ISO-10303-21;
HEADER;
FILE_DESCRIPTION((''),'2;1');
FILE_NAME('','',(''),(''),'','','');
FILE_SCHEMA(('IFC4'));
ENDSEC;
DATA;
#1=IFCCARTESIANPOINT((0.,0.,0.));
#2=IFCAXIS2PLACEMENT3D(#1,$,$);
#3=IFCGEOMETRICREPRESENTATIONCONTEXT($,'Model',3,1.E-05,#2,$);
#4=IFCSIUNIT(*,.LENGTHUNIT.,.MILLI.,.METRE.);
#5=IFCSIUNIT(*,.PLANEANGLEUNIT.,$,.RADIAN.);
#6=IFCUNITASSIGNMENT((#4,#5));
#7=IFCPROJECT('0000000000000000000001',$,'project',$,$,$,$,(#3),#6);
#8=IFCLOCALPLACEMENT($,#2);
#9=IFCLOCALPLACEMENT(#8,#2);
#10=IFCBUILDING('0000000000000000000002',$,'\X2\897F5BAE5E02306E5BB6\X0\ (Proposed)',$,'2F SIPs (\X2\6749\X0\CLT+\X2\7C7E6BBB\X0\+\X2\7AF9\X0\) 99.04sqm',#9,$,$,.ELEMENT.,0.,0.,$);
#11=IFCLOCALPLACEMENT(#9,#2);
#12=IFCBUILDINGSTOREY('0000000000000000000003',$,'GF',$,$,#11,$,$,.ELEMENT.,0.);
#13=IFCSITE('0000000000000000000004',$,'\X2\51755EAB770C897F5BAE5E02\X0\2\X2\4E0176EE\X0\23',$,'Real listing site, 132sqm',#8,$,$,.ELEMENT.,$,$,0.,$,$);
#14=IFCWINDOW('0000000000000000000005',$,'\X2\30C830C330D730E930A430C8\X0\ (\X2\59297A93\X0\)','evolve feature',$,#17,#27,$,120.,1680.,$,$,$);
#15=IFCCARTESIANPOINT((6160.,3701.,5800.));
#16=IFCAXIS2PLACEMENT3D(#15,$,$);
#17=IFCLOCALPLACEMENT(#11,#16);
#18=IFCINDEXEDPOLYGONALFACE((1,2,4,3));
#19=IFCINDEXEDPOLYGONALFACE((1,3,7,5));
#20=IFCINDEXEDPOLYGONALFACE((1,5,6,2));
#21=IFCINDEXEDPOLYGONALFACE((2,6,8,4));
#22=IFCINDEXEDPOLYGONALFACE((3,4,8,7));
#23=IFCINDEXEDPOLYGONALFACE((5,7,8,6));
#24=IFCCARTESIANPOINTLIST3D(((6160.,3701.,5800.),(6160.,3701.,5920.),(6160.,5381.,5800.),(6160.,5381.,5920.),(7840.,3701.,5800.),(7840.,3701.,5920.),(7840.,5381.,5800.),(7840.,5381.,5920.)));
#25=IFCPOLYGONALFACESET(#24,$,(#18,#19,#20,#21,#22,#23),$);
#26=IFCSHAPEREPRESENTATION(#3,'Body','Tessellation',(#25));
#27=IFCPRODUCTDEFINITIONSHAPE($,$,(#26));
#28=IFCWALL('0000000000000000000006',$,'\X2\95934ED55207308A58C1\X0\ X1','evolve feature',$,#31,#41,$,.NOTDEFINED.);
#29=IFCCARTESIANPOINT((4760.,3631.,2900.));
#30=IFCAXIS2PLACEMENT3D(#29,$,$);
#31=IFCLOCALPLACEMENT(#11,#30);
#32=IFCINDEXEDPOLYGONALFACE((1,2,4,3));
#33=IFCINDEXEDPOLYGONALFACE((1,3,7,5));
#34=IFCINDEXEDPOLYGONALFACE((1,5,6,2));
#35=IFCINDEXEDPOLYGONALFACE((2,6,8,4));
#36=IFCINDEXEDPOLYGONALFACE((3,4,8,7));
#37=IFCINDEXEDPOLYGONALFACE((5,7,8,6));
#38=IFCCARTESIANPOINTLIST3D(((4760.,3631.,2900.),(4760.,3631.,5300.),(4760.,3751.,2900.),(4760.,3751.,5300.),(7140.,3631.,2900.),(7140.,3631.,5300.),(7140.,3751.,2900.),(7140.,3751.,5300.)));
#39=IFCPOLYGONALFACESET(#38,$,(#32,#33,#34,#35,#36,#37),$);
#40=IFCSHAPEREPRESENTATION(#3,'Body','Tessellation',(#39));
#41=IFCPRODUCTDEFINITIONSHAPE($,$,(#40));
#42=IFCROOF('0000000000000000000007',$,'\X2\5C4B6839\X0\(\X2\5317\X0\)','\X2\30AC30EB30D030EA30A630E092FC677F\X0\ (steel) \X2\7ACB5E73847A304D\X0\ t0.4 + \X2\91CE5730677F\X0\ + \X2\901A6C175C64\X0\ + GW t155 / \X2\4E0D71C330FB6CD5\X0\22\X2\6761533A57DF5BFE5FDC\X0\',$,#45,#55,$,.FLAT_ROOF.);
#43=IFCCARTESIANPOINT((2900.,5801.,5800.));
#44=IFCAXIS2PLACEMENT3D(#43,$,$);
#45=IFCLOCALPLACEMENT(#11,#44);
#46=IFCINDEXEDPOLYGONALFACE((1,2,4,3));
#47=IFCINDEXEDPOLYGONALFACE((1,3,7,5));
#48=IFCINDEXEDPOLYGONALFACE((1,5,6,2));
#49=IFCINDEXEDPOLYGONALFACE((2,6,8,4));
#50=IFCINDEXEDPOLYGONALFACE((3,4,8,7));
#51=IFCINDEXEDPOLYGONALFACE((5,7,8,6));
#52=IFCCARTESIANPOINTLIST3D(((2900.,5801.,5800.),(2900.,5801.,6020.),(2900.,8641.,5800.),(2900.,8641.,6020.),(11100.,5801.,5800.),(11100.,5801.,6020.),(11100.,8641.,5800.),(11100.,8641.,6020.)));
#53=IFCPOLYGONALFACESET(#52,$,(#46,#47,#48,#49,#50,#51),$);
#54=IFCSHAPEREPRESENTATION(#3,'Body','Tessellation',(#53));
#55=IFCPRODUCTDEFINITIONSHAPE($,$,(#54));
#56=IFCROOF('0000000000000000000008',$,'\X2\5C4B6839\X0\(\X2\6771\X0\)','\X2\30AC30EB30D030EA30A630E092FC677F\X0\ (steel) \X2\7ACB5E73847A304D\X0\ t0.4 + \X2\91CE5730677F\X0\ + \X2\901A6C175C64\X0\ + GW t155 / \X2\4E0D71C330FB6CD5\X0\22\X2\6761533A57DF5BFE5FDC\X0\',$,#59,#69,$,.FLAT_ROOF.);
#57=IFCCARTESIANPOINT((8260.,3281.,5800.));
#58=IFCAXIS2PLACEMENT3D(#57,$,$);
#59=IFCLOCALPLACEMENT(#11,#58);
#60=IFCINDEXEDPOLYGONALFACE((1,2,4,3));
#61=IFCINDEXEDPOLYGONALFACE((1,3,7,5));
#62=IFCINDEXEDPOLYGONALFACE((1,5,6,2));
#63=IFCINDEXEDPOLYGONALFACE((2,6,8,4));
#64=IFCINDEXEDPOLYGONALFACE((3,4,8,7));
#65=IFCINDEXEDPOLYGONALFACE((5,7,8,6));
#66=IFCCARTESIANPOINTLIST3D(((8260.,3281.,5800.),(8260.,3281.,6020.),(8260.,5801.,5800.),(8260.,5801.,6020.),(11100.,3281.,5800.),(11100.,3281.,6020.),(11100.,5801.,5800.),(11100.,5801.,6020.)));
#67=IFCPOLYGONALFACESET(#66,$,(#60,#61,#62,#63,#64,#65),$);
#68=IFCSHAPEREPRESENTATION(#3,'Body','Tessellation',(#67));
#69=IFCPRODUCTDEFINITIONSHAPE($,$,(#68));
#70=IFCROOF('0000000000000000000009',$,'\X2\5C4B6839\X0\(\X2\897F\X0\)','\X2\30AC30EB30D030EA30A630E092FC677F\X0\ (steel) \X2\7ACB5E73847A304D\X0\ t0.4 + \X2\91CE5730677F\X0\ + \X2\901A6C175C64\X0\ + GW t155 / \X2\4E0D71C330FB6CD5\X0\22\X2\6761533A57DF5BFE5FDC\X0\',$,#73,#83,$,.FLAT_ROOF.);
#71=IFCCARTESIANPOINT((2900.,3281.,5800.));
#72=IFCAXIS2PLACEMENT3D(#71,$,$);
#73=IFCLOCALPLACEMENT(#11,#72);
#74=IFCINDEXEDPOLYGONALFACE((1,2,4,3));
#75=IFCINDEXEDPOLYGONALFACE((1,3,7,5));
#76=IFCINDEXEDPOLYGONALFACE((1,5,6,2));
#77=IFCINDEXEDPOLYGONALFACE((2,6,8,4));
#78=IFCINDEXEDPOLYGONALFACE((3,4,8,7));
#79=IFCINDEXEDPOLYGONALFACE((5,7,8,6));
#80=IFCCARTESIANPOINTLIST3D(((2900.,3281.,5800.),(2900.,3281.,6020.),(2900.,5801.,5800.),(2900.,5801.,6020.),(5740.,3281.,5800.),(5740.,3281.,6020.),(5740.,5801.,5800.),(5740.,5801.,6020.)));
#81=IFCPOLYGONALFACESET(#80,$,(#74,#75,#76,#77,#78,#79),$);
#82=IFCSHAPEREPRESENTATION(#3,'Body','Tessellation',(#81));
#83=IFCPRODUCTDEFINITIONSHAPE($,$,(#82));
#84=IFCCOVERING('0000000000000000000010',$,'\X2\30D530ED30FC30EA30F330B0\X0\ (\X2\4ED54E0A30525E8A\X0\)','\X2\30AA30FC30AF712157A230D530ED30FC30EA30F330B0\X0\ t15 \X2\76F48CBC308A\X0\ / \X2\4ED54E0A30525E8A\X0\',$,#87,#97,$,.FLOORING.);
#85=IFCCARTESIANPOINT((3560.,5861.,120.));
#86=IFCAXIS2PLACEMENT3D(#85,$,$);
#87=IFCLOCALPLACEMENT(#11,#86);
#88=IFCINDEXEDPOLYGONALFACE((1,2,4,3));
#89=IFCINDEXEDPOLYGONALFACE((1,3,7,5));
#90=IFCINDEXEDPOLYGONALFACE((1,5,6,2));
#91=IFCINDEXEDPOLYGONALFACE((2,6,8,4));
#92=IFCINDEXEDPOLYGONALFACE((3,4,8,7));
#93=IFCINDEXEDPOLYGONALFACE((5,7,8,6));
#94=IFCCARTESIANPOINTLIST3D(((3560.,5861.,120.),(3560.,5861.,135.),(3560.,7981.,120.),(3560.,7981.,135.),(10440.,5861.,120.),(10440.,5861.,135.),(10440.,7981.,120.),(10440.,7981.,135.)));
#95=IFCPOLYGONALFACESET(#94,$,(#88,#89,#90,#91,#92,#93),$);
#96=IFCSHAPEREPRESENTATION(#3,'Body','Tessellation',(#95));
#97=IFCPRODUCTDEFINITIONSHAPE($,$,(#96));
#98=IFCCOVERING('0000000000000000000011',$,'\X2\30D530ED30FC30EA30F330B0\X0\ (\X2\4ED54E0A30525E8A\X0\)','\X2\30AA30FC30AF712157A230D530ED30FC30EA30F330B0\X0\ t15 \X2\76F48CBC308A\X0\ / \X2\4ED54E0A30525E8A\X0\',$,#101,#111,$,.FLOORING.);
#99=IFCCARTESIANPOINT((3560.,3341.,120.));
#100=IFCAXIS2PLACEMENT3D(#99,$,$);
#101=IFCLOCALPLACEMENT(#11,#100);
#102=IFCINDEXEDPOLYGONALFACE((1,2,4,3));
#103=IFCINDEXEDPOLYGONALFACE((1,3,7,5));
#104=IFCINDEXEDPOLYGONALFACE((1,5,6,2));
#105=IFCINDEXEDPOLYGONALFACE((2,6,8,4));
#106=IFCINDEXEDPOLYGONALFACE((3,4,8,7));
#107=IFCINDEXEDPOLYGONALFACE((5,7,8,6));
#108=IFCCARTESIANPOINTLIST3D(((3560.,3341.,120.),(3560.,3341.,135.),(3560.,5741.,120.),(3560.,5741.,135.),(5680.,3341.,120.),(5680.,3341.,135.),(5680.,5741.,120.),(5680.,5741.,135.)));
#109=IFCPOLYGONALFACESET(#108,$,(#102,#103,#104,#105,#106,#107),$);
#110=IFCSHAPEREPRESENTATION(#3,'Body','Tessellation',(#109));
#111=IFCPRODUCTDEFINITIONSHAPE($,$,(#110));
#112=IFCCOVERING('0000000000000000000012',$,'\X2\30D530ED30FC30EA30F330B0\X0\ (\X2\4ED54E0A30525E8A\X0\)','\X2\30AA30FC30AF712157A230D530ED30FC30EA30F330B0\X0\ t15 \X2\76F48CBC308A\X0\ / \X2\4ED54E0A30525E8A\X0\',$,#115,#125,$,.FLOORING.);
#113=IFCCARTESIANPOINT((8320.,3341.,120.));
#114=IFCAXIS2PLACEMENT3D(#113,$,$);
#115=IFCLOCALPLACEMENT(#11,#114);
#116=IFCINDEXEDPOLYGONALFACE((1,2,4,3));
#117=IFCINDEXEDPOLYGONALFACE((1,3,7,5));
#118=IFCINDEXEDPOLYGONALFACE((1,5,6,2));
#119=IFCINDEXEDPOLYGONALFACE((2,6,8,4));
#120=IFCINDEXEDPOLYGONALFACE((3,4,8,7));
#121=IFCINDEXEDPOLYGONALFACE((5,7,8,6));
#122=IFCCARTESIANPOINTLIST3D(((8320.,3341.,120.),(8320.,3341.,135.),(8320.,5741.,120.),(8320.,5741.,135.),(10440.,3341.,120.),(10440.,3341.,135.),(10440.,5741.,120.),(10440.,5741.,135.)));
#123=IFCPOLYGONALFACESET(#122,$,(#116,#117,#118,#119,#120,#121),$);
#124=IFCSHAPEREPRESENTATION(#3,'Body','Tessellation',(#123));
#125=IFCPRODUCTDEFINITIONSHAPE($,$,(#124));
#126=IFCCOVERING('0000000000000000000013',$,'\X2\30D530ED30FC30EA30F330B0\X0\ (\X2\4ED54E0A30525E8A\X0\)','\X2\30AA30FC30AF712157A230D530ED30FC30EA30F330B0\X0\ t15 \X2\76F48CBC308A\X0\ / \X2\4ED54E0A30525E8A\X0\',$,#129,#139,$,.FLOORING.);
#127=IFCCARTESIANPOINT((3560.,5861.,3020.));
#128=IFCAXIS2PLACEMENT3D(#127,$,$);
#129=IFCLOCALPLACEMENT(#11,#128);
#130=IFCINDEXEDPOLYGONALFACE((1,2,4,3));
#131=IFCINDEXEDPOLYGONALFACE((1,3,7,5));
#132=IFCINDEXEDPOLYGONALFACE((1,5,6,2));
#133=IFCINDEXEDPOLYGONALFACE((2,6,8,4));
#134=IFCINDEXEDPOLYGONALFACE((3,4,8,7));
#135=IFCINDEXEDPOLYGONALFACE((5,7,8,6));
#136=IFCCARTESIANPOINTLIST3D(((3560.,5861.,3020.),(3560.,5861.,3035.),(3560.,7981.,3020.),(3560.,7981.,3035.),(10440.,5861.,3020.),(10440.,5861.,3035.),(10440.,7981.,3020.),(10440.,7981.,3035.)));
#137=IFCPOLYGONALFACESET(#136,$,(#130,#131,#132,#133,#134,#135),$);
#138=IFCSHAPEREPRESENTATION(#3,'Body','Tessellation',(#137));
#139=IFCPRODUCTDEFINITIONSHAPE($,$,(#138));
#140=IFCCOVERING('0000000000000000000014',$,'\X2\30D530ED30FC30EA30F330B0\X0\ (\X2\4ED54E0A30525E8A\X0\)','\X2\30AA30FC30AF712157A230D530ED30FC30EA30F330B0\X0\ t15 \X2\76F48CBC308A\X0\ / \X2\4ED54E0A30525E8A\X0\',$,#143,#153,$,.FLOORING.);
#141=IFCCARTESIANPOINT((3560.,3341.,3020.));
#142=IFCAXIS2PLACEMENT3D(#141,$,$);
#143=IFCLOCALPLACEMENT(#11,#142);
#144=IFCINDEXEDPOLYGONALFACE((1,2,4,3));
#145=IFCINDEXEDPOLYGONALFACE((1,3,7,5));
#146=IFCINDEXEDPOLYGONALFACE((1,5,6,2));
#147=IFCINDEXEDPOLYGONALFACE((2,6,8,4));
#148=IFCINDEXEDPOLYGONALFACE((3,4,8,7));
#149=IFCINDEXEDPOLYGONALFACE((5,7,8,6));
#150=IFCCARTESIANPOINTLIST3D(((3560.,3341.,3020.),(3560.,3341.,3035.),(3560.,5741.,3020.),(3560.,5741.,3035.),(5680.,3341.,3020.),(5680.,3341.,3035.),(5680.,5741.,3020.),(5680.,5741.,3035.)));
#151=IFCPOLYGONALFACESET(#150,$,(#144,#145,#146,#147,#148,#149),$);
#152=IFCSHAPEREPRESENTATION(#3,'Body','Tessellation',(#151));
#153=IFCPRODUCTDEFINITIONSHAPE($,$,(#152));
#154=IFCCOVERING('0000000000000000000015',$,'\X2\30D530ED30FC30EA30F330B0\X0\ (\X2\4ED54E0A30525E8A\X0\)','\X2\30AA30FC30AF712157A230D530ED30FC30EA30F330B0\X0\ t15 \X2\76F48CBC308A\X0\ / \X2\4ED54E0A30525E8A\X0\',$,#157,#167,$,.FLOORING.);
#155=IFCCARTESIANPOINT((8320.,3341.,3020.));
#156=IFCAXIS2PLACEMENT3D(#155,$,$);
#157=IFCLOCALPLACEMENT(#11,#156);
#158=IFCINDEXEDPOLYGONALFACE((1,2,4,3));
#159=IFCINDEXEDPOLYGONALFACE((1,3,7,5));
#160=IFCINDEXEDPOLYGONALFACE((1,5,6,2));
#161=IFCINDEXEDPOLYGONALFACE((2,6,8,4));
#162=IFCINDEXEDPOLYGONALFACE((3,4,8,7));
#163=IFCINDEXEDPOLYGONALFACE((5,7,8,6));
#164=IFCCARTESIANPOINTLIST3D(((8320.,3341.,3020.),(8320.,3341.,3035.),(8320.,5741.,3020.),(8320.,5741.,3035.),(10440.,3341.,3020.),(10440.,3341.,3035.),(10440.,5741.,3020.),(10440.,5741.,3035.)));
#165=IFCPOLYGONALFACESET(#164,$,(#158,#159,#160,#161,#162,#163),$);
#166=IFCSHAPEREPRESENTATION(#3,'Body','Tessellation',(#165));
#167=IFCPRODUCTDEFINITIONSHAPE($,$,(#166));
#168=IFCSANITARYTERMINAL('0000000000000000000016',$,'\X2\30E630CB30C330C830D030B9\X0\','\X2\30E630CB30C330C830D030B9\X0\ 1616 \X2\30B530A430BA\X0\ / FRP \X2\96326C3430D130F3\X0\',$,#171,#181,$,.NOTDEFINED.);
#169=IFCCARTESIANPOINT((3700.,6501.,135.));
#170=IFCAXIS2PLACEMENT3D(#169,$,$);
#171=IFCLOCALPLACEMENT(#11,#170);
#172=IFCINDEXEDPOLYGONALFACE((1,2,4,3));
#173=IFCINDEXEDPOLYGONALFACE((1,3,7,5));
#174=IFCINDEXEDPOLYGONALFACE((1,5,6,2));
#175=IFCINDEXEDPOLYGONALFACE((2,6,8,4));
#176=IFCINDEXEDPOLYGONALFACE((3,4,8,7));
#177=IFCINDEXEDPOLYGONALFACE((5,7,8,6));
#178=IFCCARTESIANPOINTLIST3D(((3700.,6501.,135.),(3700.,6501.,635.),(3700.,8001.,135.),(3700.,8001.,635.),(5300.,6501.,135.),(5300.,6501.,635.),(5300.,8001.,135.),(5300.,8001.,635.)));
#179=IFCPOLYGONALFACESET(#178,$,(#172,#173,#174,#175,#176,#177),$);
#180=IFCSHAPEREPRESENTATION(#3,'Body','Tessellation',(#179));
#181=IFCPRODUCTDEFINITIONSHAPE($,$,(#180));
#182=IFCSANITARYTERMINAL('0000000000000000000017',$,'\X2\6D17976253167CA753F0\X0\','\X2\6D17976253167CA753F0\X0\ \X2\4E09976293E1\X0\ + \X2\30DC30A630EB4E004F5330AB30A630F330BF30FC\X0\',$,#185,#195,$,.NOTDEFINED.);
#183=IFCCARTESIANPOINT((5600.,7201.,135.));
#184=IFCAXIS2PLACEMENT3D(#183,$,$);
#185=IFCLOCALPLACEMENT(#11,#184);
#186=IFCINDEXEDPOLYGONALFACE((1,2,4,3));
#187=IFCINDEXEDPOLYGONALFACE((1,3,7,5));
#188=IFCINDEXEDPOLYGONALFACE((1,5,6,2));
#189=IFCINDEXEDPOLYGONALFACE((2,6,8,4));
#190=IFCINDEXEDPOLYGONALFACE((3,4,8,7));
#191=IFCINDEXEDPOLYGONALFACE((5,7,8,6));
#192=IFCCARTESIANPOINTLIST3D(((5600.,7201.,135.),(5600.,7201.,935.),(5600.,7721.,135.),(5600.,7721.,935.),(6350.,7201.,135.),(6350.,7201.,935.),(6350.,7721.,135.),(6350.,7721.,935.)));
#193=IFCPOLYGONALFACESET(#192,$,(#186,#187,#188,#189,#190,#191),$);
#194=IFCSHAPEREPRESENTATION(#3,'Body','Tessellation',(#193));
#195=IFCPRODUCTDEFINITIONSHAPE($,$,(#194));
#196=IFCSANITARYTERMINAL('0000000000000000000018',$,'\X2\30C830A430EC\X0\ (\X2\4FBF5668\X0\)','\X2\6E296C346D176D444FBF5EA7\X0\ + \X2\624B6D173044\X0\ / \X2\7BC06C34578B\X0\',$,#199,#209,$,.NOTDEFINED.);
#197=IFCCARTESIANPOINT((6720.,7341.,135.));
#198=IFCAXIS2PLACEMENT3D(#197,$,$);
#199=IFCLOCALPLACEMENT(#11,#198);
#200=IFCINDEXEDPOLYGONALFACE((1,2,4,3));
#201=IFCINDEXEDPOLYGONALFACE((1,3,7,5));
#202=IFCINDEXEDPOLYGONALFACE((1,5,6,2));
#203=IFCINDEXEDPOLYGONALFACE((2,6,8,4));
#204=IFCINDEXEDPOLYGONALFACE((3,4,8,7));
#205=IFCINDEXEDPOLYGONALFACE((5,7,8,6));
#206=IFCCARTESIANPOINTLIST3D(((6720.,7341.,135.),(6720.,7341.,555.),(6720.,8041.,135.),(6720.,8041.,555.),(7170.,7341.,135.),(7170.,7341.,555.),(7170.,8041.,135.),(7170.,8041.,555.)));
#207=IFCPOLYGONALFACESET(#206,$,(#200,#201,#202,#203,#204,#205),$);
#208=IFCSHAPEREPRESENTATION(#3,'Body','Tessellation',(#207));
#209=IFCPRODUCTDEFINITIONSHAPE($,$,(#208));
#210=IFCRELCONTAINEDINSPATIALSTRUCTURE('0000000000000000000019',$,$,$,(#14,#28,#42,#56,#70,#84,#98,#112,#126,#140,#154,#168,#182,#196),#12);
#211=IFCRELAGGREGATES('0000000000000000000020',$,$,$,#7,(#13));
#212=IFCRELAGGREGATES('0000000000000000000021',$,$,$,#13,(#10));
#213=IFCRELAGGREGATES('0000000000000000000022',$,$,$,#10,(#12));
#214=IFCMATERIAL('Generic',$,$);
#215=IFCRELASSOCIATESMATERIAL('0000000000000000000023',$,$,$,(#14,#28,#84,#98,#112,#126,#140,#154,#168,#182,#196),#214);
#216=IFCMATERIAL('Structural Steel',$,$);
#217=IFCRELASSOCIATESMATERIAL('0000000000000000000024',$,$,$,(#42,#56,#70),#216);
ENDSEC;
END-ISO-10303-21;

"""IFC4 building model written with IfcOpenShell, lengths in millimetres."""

from ifc_helpers import new_model, si_unit, frame, frame_2d, origin, place, context, project, spatial, rectangle, extrude, material, element, save


model = new_model("IFC4")

# Units and contexts
model_context = context("Model", 3, precision=1e-05, world=origin())
ifc_project = project(units=[si_unit("LENGTHUNIT", "METRE", prefix="MILLI"), si_unit("PLANEANGLEUNIT", "RADIAN")], contexts=[model_context])

# Site, building, storey
site_placement = place(None, origin())
site = spatial("IfcSite", under=ifc_project, at=site_placement, Name="兵庫県西宮市2丁目23", ObjectType="Real listing site, 132sqm", CompositionType="ELEMENT", RefElevation=0.0)
building_placement = place(site_placement, origin())
building = spatial("IfcBuilding", under=site, at=building_placement, Name="西宮市の家 (Proposed)", ObjectType="2F SIPs (杉CLT+籾殻+竹) 99.04sqm", CompositionType="ELEMENT", ElevationOfRefHeight=0.0, ElevationOfTerrain=0.0)
storey_placement = place(building_placement, origin())
storey = spatial("IfcBuildingStorey", under=building, at=storey_placement, Name="GF", CompositionType="ELEMENT", Elevation=0.0)

# Window
ifc_material_1 = material(Name="Generic")
window_1_placement = place(storey_placement, frame((6160.0, 3701.0, 5800.0)))
element("IfcWindow", 1, at=window_1_placement, inside=storey, material=ifc_material_1, Name="トップライト (天窓)", Description="evolve feature", OverallHeight=120.0, OverallWidth=1680.0, context=model_context, shape_type="SweptSolid", body=[
    extrude(rectangle(XDim=1680.0, YDim=1680.0, at=frame_2d((840.0, 840.0))), frame((6160.0, 3701.0, 5800.0)), (0.0, 0.0, 1.0), 120.0),
])

# Wall
wall_1_placement = place(storey_placement, frame((4760.0, 3631.0, 2900.0)))
element("IfcWall", 2, at=wall_1_placement, inside=storey, material=ifc_material_1, Name="間仕切り壁 X1", Description="evolve feature", PredefinedType="NOTDEFINED", context=model_context, shape_type="SweptSolid", body=[
    extrude(rectangle(XDim=2380.0, YDim=120.0, at=frame_2d((1190.0, 60.0))), frame((4760.0, 3631.0, 2900.0)), (0.0, 0.0, 1.0), 2400.0),
])

# Roofs
ifc_material_2 = material(Name="Structural Steel")
roof_1_placement = place(storey_placement, frame((2900.0, 5801.0, 5800.0)))
element("IfcRoof", 3, at=roof_1_placement, inside=storey, material=ifc_material_2, Name="屋根(北)", Description="ガルバリウム鋼板 (steel) 立平葺き t0.4 + 野地板 + 通気層 + GW t155 / 不燃・法22条区域対応", PredefinedType="FLAT_ROOF", context=model_context, shape_type="SweptSolid", body=[
    extrude(rectangle(XDim=8200.0, YDim=2840.0, at=frame_2d((4100.0, 1420.0))), frame((2900.0, 5801.0, 5800.0)), (0.0, 0.0, 1.0), 220.0),
])
roof_2_placement = place(storey_placement, frame((8260.0, 3281.0, 5800.0)))
element("IfcRoof", 4, at=roof_2_placement, inside=storey, material=ifc_material_2, Name="屋根(東)", Description="ガルバリウム鋼板 (steel) 立平葺き t0.4 + 野地板 + 通気層 + GW t155 / 不燃・法22条区域対応", PredefinedType="FLAT_ROOF", context=model_context, shape_type="SweptSolid", body=[
    extrude(rectangle(XDim=2840.0, YDim=2520.0, at=frame_2d((1420.0, 1260.0))), frame((8260.0, 3281.0, 5800.0)), (0.0, 0.0, 1.0), 220.0),
])
roof_3_placement = place(storey_placement, frame((2900.0, 3281.0, 5800.0)))
element("IfcRoof", 5, at=roof_3_placement, inside=storey, material=ifc_material_2, Name="屋根(西)", Description="ガルバリウム鋼板 (steel) 立平葺き t0.4 + 野地板 + 通気層 + GW t155 / 不燃・法22条区域対応", PredefinedType="FLAT_ROOF", context=model_context, shape_type="SweptSolid", body=[
    extrude(rectangle(XDim=2840.0, YDim=2520.0, at=frame_2d((1420.0, 1260.0))), frame((2900.0, 3281.0, 5800.0)), (0.0, 0.0, 1.0), 220.0),
])

# Coverings
covering_1_placement = place(storey_placement, frame((3560.0, 5861.0, 120.0)))
element("IfcCovering", 6, at=covering_1_placement, inside=storey, material=ifc_material_1, Name="フローリング (仕上げ床)", Description="オーク無垢フローリング t15 直貼り / 仕上げ床", PredefinedType="FLOORING", context=model_context, shape_type="SweptSolid", body=[
    extrude(rectangle(XDim=6880.0, YDim=2120.0, at=frame_2d((3440.0, 1060.0))), frame((3560.0, 5861.0, 120.0)), (0.0, 0.0, 1.0), 15.0),
])
covering_2_placement = place(storey_placement, frame((3560.0, 3341.0, 120.0)))
element("IfcCovering", 7, at=covering_2_placement, inside=storey, material=ifc_material_1, Name="フローリング (仕上げ床)", Description="オーク無垢フローリング t15 直貼り / 仕上げ床", PredefinedType="FLOORING", context=model_context, shape_type="SweptSolid", body=[
    extrude(rectangle(XDim=2120.0, YDim=2400.0, at=frame_2d((1060.0, 1200.0))), frame((3560.0, 3341.0, 120.0)), (0.0, 0.0, 1.0), 15.0),
])
covering_3_placement = place(storey_placement, frame((8320.0, 3341.0, 120.0)))
element("IfcCovering", 8, at=covering_3_placement, inside=storey, material=ifc_material_1, Name="フローリング (仕上げ床)", Description="オーク無垢フローリング t15 直貼り / 仕上げ床", PredefinedType="FLOORING", context=model_context, shape_type="SweptSolid", body=[
    extrude(rectangle(XDim=2120.0, YDim=2400.0, at=frame_2d((1060.0, 1200.0))), frame((8320.0, 3341.0, 120.0)), (0.0, 0.0, 1.0), 15.0),
])
covering_4_placement = place(storey_placement, frame((3560.0, 5861.0, 3020.0)))
element("IfcCovering", 9, at=covering_4_placement, inside=storey, material=ifc_material_1, Name="フローリング (仕上げ床)", Description="オーク無垢フローリング t15 直貼り / 仕上げ床", PredefinedType="FLOORING", context=model_context, shape_type="SweptSolid", body=[
    extrude(rectangle(XDim=6880.0, YDim=2120.0, at=frame_2d((3440.0, 1060.0))), frame((3560.0, 5861.0, 3020.0)), (0.0, 0.0, 1.0), 15.0),
])
covering_5_placement = place(storey_placement, frame((3560.0, 3341.0, 3020.0)))
element("IfcCovering", 10, at=covering_5_placement, inside=storey, material=ifc_material_1, Name="フローリング (仕上げ床)", Description="オーク無垢フローリング t15 直貼り / 仕上げ床", PredefinedType="FLOORING", context=model_context, shape_type="SweptSolid", body=[
    extrude(rectangle(XDim=2120.0, YDim=2400.0, at=frame_2d((1060.0, 1200.0))), frame((3560.0, 3341.0, 3020.0)), (0.0, 0.0, 1.0), 15.0),
])
covering_6_placement = place(storey_placement, frame((8320.0, 3341.0, 3020.0)))
element("IfcCovering", 11, at=covering_6_placement, inside=storey, material=ifc_material_1, Name="フローリング (仕上げ床)", Description="オーク無垢フローリング t15 直貼り / 仕上げ床", PredefinedType="FLOORING", context=model_context, shape_type="SweptSolid", body=[
    extrude(rectangle(XDim=2120.0, YDim=2400.0, at=frame_2d((1060.0, 1200.0))), frame((8320.0, 3341.0, 3020.0)), (0.0, 0.0, 1.0), 15.0),
])

# Sanitary terminals
sanitary_terminal_1_placement = place(storey_placement, frame((3700.0, 6501.0, 135.0)))
element("IfcSanitaryTerminal", 12, at=sanitary_terminal_1_placement, inside=storey, material=ifc_material_1, Name="ユニットバス", Description="ユニットバス 1616 サイズ / FRP 防水パン", PredefinedType="NOTDEFINED", context=model_context, shape_type="SweptSolid", body=[
    extrude(rectangle(XDim=1600.0, YDim=1500.0, at=frame_2d((800.0, 750.0))), frame((3700.0, 6501.0, 135.0)), (0.0, 0.0, 1.0), 500.0),
])
sanitary_terminal_2_placement = place(storey_placement, frame((5600.0, 7201.0, 135.0)))
element("IfcSanitaryTerminal", 13, at=sanitary_terminal_2_placement, inside=storey, material=ifc_material_1, Name="洗面化粧台", Description="洗面化粧台 三面鏡 + ボウル一体カウンター", PredefinedType="NOTDEFINED", context=model_context, shape_type="SweptSolid", body=[
    extrude(rectangle(XDim=750.0, YDim=520.0, at=frame_2d((375.0, 260.0))), frame((5600.0, 7201.0, 135.0)), (0.0, 0.0, 1.0), 800.0),
])
sanitary_terminal_3_placement = place(storey_placement, frame((6720.0, 7341.0, 135.0)))
element("IfcSanitaryTerminal", 14, at=sanitary_terminal_3_placement, inside=storey, material=ifc_material_1, Name="トイレ (便器)", Description="温水洗浄便座 + 手洗い / 節水型", PredefinedType="NOTDEFINED", context=model_context, shape_type="SweptSolid", body=[
    extrude(rectangle(XDim=450.0, YDim=700.0, at=frame_2d((225.0, 350.0))), frame((6720.0, 7341.0, 135.0)), (0.0, 0.0, 1.0), 420.0),
])

save(model, "model.ifc")
